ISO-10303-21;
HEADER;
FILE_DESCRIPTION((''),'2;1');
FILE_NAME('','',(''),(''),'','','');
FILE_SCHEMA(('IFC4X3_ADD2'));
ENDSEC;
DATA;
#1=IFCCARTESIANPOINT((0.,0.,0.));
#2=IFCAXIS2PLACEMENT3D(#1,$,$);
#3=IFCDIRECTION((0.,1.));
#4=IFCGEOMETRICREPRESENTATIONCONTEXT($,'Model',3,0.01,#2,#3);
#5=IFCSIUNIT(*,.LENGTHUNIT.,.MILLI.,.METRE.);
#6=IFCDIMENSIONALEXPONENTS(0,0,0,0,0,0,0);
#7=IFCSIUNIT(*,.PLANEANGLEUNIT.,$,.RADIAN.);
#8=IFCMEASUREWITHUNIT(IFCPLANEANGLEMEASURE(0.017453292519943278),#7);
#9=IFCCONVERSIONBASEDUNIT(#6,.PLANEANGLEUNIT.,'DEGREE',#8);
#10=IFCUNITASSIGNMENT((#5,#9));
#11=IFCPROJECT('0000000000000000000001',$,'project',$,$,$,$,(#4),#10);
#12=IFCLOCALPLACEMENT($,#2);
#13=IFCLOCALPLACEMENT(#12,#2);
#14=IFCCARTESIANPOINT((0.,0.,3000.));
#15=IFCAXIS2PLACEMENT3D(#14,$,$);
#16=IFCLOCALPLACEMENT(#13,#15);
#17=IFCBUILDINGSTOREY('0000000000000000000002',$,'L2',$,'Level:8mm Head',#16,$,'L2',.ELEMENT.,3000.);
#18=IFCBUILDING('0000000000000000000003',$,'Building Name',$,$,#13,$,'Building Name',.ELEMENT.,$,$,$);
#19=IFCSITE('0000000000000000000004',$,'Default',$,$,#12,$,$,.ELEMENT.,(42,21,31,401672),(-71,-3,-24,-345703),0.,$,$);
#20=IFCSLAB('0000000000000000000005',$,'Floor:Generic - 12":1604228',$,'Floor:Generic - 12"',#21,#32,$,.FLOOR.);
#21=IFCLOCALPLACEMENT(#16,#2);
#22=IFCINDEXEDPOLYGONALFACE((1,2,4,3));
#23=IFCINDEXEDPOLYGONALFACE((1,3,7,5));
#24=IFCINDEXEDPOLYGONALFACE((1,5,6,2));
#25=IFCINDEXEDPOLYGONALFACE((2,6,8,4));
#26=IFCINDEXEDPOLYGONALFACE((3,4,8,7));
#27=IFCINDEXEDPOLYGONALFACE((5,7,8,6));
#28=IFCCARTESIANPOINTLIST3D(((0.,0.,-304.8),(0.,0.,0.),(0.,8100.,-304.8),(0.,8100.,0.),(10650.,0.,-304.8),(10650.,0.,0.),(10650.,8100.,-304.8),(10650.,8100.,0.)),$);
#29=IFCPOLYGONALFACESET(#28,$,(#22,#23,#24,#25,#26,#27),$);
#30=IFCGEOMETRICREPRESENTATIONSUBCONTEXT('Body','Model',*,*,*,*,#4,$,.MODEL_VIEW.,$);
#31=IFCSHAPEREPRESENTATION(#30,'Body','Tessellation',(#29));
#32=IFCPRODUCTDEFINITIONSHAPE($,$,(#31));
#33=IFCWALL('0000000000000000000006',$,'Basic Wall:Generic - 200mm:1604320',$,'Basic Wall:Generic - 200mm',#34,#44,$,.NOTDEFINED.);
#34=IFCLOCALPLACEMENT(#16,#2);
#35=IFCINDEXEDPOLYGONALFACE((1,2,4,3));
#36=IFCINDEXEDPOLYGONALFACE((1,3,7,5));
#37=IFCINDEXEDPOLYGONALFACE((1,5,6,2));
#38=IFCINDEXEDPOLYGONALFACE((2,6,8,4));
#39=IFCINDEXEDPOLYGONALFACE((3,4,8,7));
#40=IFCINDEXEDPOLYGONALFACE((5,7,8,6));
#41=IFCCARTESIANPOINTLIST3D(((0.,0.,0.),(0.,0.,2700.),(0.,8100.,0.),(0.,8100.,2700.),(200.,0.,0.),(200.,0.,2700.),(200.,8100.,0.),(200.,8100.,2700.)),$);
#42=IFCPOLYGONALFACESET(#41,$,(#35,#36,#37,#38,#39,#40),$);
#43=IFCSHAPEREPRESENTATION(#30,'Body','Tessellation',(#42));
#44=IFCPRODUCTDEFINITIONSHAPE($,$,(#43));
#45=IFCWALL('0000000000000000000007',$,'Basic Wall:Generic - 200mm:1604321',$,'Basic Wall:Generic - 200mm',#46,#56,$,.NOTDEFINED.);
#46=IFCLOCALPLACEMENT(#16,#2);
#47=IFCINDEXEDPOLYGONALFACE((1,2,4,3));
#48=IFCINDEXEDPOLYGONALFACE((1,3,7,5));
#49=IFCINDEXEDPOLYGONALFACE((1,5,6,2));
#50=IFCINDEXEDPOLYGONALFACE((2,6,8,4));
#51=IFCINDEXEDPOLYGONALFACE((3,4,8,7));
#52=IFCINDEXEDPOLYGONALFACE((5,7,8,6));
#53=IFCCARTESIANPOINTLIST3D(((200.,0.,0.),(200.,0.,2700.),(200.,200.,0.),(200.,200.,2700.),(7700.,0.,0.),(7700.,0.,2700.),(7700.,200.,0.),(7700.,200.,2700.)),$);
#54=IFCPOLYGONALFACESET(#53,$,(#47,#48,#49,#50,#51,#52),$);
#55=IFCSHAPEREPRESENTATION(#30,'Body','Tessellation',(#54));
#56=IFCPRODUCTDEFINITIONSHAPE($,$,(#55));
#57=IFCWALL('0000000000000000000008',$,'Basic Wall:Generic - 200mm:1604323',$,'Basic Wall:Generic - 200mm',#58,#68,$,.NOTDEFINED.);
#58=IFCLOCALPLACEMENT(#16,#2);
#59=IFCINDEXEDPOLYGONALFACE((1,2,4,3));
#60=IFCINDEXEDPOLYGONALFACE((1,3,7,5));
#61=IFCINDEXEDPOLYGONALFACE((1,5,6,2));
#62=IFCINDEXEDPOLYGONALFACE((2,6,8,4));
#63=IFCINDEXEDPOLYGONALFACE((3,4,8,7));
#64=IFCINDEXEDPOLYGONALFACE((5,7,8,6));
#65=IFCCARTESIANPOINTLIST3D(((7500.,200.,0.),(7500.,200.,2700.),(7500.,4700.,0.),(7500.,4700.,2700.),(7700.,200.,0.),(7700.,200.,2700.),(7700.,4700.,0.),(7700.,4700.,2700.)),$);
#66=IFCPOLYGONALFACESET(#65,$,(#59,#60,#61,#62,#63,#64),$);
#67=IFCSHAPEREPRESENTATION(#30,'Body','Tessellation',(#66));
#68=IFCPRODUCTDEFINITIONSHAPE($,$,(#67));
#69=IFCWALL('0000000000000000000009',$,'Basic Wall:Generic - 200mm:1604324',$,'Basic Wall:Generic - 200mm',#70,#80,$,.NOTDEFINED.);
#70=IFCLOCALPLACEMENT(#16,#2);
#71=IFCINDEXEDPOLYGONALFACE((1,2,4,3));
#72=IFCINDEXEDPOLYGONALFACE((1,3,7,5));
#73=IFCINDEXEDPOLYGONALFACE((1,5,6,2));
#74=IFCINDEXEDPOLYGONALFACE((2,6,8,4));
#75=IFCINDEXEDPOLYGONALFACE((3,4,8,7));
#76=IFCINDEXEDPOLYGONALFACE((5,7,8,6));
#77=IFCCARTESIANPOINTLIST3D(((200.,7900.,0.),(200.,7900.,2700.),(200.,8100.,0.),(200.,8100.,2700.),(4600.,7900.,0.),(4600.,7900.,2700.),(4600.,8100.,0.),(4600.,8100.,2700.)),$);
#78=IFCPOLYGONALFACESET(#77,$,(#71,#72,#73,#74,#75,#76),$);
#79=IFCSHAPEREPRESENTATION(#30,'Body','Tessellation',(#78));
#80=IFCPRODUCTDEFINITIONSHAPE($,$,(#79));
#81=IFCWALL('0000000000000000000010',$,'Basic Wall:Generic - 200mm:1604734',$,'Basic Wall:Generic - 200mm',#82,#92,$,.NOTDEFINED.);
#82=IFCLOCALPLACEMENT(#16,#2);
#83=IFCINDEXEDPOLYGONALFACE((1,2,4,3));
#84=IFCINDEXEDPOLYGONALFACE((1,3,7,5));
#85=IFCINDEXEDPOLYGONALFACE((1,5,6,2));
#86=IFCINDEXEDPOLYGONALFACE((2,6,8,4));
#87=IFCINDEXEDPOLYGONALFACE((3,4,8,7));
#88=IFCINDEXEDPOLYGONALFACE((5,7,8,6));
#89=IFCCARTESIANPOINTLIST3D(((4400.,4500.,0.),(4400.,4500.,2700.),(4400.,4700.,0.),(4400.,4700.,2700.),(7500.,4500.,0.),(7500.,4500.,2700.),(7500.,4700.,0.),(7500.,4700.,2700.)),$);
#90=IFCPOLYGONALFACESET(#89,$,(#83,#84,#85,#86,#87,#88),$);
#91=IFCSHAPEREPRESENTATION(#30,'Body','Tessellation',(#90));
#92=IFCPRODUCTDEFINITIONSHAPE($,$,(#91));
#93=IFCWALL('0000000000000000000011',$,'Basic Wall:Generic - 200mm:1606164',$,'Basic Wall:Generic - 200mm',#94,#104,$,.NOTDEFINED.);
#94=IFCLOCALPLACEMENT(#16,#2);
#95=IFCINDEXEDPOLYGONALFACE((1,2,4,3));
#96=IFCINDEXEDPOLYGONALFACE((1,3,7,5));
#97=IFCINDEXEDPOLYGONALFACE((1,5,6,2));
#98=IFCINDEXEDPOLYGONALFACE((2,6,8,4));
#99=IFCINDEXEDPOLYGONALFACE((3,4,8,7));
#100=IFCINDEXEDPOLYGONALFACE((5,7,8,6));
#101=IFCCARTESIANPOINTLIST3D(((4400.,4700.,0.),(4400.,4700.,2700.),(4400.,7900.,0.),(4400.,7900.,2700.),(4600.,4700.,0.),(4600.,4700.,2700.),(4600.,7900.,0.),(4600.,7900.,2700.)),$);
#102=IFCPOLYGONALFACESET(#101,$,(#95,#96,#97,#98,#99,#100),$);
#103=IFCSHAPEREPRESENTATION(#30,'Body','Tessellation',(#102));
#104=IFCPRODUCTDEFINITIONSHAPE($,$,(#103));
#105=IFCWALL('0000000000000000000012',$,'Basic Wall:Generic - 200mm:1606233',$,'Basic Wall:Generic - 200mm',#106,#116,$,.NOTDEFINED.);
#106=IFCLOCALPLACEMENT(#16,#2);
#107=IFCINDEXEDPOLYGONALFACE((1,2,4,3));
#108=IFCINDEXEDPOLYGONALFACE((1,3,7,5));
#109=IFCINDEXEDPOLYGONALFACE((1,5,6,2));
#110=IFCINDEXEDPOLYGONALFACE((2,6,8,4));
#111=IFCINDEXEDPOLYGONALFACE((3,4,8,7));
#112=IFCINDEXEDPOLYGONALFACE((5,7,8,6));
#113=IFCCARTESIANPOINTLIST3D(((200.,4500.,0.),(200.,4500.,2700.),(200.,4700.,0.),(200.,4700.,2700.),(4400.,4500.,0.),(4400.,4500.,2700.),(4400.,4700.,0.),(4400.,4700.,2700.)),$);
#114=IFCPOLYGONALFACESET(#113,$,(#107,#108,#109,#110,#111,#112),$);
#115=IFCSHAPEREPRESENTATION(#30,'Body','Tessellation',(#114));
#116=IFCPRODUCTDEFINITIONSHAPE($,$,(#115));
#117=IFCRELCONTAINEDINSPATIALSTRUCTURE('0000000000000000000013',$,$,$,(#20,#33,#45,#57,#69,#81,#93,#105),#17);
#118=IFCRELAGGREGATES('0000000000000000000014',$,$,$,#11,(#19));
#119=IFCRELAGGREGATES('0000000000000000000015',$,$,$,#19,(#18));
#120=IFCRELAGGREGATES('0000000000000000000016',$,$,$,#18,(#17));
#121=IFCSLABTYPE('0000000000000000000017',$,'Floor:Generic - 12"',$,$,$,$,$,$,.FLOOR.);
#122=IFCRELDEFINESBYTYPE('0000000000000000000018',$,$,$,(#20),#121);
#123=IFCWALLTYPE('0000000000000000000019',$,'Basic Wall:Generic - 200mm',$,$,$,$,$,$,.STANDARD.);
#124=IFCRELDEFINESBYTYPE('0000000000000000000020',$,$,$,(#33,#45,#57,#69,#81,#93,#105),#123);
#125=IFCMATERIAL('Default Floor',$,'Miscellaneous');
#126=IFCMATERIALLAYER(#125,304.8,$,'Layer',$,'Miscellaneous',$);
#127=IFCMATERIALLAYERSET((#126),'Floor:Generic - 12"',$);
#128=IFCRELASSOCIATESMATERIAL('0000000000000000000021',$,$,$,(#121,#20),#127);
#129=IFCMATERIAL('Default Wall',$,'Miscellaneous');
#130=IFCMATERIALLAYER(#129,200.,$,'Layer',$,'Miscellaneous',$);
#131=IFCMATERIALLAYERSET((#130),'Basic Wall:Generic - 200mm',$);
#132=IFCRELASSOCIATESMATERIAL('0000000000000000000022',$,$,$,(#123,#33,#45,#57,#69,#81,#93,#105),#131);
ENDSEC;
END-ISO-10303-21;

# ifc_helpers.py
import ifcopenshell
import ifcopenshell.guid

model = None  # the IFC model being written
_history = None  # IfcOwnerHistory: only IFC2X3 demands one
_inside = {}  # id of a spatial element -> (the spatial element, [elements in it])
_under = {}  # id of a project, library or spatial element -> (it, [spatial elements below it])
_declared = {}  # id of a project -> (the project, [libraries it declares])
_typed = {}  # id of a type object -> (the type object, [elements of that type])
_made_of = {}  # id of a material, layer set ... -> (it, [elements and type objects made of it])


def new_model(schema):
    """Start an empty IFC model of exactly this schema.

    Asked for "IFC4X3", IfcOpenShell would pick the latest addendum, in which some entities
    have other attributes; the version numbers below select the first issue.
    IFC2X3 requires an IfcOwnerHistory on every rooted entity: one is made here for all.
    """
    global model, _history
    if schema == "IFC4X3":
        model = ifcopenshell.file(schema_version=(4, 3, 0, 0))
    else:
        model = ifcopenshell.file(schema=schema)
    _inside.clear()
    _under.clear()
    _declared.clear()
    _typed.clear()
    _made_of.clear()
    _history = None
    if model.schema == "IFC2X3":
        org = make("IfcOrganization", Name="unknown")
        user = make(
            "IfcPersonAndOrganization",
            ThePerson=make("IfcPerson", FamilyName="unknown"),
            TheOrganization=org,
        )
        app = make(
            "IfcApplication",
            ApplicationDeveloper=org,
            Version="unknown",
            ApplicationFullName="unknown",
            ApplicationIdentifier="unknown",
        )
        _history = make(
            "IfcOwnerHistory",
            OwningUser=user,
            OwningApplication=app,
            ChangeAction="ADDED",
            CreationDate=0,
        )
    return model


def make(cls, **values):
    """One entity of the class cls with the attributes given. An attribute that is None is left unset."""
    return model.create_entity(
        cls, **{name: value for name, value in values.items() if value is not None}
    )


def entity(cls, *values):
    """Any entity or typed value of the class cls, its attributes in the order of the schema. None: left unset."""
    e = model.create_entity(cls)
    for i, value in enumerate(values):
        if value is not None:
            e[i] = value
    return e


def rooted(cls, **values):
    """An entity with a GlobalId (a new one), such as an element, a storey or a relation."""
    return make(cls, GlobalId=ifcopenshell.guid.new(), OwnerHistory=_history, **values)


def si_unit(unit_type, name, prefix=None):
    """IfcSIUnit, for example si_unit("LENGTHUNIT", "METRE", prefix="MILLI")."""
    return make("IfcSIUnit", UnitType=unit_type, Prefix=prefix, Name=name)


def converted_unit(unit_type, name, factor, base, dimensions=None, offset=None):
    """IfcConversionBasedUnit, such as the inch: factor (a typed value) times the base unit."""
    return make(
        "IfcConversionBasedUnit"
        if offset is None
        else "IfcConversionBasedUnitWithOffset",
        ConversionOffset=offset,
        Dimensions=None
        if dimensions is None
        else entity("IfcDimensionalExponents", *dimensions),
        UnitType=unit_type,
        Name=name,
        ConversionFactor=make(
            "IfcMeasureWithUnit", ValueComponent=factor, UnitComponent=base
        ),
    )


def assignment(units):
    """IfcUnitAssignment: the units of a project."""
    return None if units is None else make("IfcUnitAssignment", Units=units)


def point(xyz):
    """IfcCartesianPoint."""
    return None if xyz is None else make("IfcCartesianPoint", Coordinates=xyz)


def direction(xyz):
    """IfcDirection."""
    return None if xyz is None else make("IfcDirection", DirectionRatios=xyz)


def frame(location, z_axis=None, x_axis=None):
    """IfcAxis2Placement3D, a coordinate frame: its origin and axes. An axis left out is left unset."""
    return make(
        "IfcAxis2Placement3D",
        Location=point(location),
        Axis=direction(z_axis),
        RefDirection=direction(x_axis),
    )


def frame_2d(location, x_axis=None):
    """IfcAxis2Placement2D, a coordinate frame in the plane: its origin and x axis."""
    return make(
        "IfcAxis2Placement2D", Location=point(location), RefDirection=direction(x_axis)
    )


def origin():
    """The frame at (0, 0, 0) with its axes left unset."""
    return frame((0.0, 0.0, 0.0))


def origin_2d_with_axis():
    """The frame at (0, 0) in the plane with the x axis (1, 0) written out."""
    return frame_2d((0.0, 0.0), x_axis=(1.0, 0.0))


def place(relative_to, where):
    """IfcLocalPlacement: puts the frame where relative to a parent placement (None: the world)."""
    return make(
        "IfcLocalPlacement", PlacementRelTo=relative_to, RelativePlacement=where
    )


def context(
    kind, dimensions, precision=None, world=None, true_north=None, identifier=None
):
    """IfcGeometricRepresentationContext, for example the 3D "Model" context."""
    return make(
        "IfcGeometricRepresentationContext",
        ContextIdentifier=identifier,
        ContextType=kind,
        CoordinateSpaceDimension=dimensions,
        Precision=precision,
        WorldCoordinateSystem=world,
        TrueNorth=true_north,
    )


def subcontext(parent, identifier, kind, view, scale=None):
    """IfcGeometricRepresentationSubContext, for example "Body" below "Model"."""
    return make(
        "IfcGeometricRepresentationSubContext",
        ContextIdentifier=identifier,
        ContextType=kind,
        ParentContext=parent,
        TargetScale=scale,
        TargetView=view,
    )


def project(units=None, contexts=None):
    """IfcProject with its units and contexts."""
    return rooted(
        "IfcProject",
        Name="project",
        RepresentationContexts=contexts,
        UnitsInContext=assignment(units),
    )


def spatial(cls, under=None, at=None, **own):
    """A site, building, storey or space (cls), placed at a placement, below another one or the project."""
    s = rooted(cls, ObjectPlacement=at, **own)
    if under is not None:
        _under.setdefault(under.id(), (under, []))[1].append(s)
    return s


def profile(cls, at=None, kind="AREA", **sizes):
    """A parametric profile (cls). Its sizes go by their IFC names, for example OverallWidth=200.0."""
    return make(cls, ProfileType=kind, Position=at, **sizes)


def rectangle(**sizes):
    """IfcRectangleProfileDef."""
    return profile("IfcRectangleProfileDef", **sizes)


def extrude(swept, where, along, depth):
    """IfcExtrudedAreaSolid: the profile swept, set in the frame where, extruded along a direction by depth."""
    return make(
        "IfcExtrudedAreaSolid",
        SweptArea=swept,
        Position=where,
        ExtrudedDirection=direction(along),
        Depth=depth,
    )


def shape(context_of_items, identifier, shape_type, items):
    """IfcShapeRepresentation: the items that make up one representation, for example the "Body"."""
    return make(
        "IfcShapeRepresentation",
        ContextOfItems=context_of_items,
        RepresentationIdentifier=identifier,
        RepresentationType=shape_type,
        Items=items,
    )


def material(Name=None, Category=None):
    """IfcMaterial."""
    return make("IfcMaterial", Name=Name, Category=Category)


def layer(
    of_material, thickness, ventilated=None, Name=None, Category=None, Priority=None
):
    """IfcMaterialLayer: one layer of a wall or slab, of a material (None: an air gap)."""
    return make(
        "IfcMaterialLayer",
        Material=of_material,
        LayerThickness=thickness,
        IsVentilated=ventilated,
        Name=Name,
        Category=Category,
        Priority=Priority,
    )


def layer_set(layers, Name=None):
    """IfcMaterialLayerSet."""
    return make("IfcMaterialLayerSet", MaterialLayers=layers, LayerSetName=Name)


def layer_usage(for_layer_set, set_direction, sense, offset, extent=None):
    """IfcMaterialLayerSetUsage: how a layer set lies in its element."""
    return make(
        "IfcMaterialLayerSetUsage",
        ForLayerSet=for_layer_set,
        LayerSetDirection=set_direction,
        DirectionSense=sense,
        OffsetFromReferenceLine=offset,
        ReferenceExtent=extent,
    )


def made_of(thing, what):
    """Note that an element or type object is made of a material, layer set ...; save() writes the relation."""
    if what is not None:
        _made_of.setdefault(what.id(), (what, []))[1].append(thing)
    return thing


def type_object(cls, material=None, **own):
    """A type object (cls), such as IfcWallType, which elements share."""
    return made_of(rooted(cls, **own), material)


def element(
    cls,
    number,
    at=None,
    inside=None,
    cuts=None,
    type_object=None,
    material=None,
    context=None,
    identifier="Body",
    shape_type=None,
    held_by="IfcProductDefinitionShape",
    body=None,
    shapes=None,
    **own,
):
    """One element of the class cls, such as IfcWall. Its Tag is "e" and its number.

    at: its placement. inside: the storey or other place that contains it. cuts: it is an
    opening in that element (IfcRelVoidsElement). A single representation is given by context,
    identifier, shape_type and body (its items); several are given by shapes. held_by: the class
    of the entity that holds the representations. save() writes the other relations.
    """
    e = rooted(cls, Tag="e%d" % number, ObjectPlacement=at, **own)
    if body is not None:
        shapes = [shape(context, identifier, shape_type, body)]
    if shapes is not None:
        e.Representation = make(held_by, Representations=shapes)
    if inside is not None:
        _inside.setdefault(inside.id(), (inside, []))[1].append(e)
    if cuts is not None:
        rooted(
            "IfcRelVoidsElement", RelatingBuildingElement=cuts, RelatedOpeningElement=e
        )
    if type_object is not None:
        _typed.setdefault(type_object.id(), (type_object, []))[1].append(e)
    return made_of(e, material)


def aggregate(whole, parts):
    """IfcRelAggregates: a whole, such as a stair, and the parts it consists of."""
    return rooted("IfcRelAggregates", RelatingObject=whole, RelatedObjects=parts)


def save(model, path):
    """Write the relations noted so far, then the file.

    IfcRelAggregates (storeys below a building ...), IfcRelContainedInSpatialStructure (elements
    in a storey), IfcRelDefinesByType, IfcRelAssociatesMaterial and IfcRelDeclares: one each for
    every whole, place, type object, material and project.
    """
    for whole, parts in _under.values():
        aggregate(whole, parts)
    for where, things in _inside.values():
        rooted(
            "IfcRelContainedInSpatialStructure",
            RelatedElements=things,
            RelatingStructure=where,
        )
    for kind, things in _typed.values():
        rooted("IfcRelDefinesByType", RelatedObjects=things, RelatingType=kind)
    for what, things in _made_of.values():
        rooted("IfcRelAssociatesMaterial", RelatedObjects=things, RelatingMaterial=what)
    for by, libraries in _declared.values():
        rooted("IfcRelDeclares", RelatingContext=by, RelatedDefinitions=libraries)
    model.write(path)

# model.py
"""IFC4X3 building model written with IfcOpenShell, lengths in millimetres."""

from ifc_helpers import new_model, entity, si_unit, converted_unit, direction, frame, frame_2d, origin, origin_2d_with_axis, place, context, subcontext, project, spatial, rectangle, extrude, material, layer, layer_set, layer_usage, type_object, element, save


model = new_model("IFC4X3")

# Units and contexts
model_context = context("Model", 3, precision=0.01, world=origin(), true_north=direction((0.0, 1.0)))
body_context = subcontext(model_context, "Body", "Model", "MODEL_VIEW")
ifc_project = project(units=[si_unit("LENGTHUNIT", "METRE", prefix="MILLI"), converted_unit("PLANEANGLEUNIT", "DEGREE", entity("IfcPlaneAngleMeasure", 0.017453292519943278), si_unit("PLANEANGLEUNIT", "RADIAN"), dimensions=[0, 0, 0, 0, 0, 0, 0])], contexts=[model_context])

# Site, building, storey
site_placement = place(None, origin())
site = spatial("IfcSite", under=ifc_project, at=site_placement, Name="Default", CompositionType="ELEMENT", RefLatitude=(42, 21, 31, 401672), RefLongitude=(-71, -3, -24, -345703), RefElevation=0.0)
building_placement = place(site_placement, origin())
building = spatial("IfcBuilding", under=site, at=building_placement, Name="Building Name", LongName="Building Name", CompositionType="ELEMENT")
storey_placement = place(building_placement, frame((0.0, 0.0, 3000.0)))
storey = spatial("IfcBuildingStorey", under=building, at=storey_placement, Name="L2", ObjectType="Level:8mm Head", LongName="L2", CompositionType="ELEMENT", Elevation=3000.0)

# Slab
ifc_material_1 = material(Name="Default Floor", Category="Miscellaneous")
ifc_layer_1 = layer(ifc_material_1, 304.8, Name="Layer", Category="Miscellaneous")
ifc_layer_set_1 = layer_set([ifc_layer_1], Name="Floor:Generic - 12\"")
ifc_layer_usage = layer_usage(ifc_layer_set_1, "AXIS3", "POSITIVE", 0.0)
slab_type = type_object("IfcSlabType", Name="Floor:Generic - 12\"", PredefinedType="FLOOR", material=ifc_layer_set_1)
slab_placement = place(storey_placement, origin())
element("IfcSlab", 1, at=slab_placement, inside=storey, type_object=slab_type, material=ifc_layer_usage, Name="Floor:Generic - 12\":1604228", ObjectType="Floor:Generic - 12\"", PredefinedType="FLOOR", context=body_context, shape_type="SweptSolid", body=[
    extrude(rectangle(XDim=8100.0, YDim=10650.0, at=origin_2d_with_axis()), frame((5325.0, 4050.0, 0.0), z_axis=(0.0, 0.0, -1.0), x_axis=(0.0, 1.0, 0.0)), (0.0, 0.0, 1.0), 304.8),
])

# Walls
ifc_material_2 = material(Name="Default Wall", Category="Miscellaneous")
ifc_layer_2 = layer(ifc_material_2, 200.0, Name="Layer", Category="Miscellaneous")
ifc_layer_set_2 = layer_set([ifc_layer_2], Name="Basic Wall:Generic - 200mm")
wall_type = type_object("IfcWallType", Name="Basic Wall:Generic - 200mm", PredefinedType="STANDARD", material=ifc_layer_set_2)
wall_1_placement = place(storey_placement, frame((100.0, 8100.0, 0.0), z_axis=(0.0, 0.0, 1.0), x_axis=(0.0, -1.0, 0.0)))
element("IfcWall", 2, at=wall_1_placement, inside=storey, type_object=wall_type, material=ifc_layer_set_2, Name="Basic Wall:Generic - 200mm:1604320", ObjectType="Basic Wall:Generic - 200mm", PredefinedType="NOTDEFINED", context=body_context, shape_type="SweptSolid", body=[
    extrude(rectangle(XDim=8100.0, YDim=200.0, at=frame_2d((4050.0, 0.0), x_axis=(-1.0, 0.0))), origin(), (0.0, 0.0, 1.0), 2700.0),
])
wall_2_placement = place(storey_placement, frame((200.0, 100.0, 0.0)))
element("IfcWall", 3, at=wall_2_placement, inside=storey, type_object=wall_type, material=ifc_layer_set_2, Name="Basic Wall:Generic - 200mm:1604321", ObjectType="Basic Wall:Generic - 200mm", PredefinedType="NOTDEFINED", context=body_context, shape_type="SweptSolid", body=[
    extrude(rectangle(XDim=7500.0, YDim=200.0, at=frame_2d((3750.0, 0.0), x_axis=(-1.0, 0.0))), origin(), (0.0, 0.0, 1.0), 2700.0),
])
wall_3_placement = place(storey_placement, frame((7600.0, 200.0, 0.0), z_axis=(0.0, 0.0, 1.0), x_axis=(0.0, 1.0, 0.0)))
element("IfcWall", 4, at=wall_3_placement, inside=storey, type_object=wall_type, material=ifc_layer_set_2, Name="Basic Wall:Generic - 200mm:1604323", ObjectType="Basic Wall:Generic - 200mm", PredefinedType="NOTDEFINED", context=body_context, shape_type="SweptSolid", body=[
    extrude(rectangle(XDim=4500.0, YDim=200.0, at=frame_2d((2250.0, 0.0), x_axis=(-1.0, 0.0))), origin(), (0.0, 0.0, 1.0), 2700.0),
])
wall_4_placement = place(storey_placement, frame((4600.0, 8000.0, 0.0), z_axis=(0.0, 0.0, 1.0), x_axis=(-1.0, 0.0, 0.0)))
element("IfcWall", 5, at=wall_4_placement, inside=storey, type_object=wall_type, material=ifc_layer_set_2, Name="Basic Wall:Generic - 200mm:1604324", ObjectType="Basic Wall:Generic - 200mm", PredefinedType="NOTDEFINED", context=body_context, shape_type="SweptSolid", body=[
    extrude(rectangle(XDim=4400.0, YDim=200.0, at=frame_2d((2200.0, 0.0), x_axis=(-1.0, 0.0))), origin(), (0.0, 0.0, 1.0), 2700.0),
])
wall_5_placement = place(storey_placement, frame((7500.0, 4600.0, 0.0), z_axis=(0.0, 0.0, 1.0), x_axis=(-1.0, 0.0, 0.0)))
element("IfcWall", 6, at=wall_5_placement, inside=storey, type_object=wall_type, material=ifc_layer_set_2, Name="Basic Wall:Generic - 200mm:1604734", ObjectType="Basic Wall:Generic - 200mm", PredefinedType="NOTDEFINED", context=body_context, shape_type="SweptSolid", body=[
    extrude(rectangle(XDim=3100.0, YDim=200.0, at=frame_2d((1550.0, 0.0), x_axis=(-1.0, 0.0))), origin(), (0.0, 0.0, 1.0), 2700.0),
])
wall_6_placement = place(storey_placement, frame((4500.0, 7900.0, 0.0), z_axis=(0.0, 0.0, 1.0), x_axis=(0.0, -1.0, 0.0)))
element("IfcWall", 7, at=wall_6_placement, inside=storey, type_object=wall_type, material=ifc_layer_set_2, Name="Basic Wall:Generic - 200mm:1606164", ObjectType="Basic Wall:Generic - 200mm", PredefinedType="NOTDEFINED", context=body_context, shape_type="SweptSolid", body=[
    extrude(rectangle(XDim=3200.0, YDim=200.0, at=frame_2d((1600.0, 0.0), x_axis=(-1.0, 0.0))), origin(), (0.0, 0.0, 1.0), 2700.0),
])
wall_7_placement = place(storey_placement, frame((4400.0, 4600.0, 0.0), z_axis=(0.0, 0.0, 1.0), x_axis=(-1.0, 0.0, 0.0)))
element("IfcWall", 8, at=wall_7_placement, inside=storey, type_object=wall_type, material=ifc_layer_set_2, Name="Basic Wall:Generic - 200mm:1606233", ObjectType="Basic Wall:Generic - 200mm", PredefinedType="NOTDEFINED", context=body_context, shape_type="SweptSolid", body=[
    extrude(rectangle(XDim=4200.0, YDim=200.0, at=frame_2d((2100.0, 0.0), x_axis=(-1.0, 0.0))), origin(), (0.0, 0.0, 1.0), 2700.0),
])

save(model, "model.ifc")
